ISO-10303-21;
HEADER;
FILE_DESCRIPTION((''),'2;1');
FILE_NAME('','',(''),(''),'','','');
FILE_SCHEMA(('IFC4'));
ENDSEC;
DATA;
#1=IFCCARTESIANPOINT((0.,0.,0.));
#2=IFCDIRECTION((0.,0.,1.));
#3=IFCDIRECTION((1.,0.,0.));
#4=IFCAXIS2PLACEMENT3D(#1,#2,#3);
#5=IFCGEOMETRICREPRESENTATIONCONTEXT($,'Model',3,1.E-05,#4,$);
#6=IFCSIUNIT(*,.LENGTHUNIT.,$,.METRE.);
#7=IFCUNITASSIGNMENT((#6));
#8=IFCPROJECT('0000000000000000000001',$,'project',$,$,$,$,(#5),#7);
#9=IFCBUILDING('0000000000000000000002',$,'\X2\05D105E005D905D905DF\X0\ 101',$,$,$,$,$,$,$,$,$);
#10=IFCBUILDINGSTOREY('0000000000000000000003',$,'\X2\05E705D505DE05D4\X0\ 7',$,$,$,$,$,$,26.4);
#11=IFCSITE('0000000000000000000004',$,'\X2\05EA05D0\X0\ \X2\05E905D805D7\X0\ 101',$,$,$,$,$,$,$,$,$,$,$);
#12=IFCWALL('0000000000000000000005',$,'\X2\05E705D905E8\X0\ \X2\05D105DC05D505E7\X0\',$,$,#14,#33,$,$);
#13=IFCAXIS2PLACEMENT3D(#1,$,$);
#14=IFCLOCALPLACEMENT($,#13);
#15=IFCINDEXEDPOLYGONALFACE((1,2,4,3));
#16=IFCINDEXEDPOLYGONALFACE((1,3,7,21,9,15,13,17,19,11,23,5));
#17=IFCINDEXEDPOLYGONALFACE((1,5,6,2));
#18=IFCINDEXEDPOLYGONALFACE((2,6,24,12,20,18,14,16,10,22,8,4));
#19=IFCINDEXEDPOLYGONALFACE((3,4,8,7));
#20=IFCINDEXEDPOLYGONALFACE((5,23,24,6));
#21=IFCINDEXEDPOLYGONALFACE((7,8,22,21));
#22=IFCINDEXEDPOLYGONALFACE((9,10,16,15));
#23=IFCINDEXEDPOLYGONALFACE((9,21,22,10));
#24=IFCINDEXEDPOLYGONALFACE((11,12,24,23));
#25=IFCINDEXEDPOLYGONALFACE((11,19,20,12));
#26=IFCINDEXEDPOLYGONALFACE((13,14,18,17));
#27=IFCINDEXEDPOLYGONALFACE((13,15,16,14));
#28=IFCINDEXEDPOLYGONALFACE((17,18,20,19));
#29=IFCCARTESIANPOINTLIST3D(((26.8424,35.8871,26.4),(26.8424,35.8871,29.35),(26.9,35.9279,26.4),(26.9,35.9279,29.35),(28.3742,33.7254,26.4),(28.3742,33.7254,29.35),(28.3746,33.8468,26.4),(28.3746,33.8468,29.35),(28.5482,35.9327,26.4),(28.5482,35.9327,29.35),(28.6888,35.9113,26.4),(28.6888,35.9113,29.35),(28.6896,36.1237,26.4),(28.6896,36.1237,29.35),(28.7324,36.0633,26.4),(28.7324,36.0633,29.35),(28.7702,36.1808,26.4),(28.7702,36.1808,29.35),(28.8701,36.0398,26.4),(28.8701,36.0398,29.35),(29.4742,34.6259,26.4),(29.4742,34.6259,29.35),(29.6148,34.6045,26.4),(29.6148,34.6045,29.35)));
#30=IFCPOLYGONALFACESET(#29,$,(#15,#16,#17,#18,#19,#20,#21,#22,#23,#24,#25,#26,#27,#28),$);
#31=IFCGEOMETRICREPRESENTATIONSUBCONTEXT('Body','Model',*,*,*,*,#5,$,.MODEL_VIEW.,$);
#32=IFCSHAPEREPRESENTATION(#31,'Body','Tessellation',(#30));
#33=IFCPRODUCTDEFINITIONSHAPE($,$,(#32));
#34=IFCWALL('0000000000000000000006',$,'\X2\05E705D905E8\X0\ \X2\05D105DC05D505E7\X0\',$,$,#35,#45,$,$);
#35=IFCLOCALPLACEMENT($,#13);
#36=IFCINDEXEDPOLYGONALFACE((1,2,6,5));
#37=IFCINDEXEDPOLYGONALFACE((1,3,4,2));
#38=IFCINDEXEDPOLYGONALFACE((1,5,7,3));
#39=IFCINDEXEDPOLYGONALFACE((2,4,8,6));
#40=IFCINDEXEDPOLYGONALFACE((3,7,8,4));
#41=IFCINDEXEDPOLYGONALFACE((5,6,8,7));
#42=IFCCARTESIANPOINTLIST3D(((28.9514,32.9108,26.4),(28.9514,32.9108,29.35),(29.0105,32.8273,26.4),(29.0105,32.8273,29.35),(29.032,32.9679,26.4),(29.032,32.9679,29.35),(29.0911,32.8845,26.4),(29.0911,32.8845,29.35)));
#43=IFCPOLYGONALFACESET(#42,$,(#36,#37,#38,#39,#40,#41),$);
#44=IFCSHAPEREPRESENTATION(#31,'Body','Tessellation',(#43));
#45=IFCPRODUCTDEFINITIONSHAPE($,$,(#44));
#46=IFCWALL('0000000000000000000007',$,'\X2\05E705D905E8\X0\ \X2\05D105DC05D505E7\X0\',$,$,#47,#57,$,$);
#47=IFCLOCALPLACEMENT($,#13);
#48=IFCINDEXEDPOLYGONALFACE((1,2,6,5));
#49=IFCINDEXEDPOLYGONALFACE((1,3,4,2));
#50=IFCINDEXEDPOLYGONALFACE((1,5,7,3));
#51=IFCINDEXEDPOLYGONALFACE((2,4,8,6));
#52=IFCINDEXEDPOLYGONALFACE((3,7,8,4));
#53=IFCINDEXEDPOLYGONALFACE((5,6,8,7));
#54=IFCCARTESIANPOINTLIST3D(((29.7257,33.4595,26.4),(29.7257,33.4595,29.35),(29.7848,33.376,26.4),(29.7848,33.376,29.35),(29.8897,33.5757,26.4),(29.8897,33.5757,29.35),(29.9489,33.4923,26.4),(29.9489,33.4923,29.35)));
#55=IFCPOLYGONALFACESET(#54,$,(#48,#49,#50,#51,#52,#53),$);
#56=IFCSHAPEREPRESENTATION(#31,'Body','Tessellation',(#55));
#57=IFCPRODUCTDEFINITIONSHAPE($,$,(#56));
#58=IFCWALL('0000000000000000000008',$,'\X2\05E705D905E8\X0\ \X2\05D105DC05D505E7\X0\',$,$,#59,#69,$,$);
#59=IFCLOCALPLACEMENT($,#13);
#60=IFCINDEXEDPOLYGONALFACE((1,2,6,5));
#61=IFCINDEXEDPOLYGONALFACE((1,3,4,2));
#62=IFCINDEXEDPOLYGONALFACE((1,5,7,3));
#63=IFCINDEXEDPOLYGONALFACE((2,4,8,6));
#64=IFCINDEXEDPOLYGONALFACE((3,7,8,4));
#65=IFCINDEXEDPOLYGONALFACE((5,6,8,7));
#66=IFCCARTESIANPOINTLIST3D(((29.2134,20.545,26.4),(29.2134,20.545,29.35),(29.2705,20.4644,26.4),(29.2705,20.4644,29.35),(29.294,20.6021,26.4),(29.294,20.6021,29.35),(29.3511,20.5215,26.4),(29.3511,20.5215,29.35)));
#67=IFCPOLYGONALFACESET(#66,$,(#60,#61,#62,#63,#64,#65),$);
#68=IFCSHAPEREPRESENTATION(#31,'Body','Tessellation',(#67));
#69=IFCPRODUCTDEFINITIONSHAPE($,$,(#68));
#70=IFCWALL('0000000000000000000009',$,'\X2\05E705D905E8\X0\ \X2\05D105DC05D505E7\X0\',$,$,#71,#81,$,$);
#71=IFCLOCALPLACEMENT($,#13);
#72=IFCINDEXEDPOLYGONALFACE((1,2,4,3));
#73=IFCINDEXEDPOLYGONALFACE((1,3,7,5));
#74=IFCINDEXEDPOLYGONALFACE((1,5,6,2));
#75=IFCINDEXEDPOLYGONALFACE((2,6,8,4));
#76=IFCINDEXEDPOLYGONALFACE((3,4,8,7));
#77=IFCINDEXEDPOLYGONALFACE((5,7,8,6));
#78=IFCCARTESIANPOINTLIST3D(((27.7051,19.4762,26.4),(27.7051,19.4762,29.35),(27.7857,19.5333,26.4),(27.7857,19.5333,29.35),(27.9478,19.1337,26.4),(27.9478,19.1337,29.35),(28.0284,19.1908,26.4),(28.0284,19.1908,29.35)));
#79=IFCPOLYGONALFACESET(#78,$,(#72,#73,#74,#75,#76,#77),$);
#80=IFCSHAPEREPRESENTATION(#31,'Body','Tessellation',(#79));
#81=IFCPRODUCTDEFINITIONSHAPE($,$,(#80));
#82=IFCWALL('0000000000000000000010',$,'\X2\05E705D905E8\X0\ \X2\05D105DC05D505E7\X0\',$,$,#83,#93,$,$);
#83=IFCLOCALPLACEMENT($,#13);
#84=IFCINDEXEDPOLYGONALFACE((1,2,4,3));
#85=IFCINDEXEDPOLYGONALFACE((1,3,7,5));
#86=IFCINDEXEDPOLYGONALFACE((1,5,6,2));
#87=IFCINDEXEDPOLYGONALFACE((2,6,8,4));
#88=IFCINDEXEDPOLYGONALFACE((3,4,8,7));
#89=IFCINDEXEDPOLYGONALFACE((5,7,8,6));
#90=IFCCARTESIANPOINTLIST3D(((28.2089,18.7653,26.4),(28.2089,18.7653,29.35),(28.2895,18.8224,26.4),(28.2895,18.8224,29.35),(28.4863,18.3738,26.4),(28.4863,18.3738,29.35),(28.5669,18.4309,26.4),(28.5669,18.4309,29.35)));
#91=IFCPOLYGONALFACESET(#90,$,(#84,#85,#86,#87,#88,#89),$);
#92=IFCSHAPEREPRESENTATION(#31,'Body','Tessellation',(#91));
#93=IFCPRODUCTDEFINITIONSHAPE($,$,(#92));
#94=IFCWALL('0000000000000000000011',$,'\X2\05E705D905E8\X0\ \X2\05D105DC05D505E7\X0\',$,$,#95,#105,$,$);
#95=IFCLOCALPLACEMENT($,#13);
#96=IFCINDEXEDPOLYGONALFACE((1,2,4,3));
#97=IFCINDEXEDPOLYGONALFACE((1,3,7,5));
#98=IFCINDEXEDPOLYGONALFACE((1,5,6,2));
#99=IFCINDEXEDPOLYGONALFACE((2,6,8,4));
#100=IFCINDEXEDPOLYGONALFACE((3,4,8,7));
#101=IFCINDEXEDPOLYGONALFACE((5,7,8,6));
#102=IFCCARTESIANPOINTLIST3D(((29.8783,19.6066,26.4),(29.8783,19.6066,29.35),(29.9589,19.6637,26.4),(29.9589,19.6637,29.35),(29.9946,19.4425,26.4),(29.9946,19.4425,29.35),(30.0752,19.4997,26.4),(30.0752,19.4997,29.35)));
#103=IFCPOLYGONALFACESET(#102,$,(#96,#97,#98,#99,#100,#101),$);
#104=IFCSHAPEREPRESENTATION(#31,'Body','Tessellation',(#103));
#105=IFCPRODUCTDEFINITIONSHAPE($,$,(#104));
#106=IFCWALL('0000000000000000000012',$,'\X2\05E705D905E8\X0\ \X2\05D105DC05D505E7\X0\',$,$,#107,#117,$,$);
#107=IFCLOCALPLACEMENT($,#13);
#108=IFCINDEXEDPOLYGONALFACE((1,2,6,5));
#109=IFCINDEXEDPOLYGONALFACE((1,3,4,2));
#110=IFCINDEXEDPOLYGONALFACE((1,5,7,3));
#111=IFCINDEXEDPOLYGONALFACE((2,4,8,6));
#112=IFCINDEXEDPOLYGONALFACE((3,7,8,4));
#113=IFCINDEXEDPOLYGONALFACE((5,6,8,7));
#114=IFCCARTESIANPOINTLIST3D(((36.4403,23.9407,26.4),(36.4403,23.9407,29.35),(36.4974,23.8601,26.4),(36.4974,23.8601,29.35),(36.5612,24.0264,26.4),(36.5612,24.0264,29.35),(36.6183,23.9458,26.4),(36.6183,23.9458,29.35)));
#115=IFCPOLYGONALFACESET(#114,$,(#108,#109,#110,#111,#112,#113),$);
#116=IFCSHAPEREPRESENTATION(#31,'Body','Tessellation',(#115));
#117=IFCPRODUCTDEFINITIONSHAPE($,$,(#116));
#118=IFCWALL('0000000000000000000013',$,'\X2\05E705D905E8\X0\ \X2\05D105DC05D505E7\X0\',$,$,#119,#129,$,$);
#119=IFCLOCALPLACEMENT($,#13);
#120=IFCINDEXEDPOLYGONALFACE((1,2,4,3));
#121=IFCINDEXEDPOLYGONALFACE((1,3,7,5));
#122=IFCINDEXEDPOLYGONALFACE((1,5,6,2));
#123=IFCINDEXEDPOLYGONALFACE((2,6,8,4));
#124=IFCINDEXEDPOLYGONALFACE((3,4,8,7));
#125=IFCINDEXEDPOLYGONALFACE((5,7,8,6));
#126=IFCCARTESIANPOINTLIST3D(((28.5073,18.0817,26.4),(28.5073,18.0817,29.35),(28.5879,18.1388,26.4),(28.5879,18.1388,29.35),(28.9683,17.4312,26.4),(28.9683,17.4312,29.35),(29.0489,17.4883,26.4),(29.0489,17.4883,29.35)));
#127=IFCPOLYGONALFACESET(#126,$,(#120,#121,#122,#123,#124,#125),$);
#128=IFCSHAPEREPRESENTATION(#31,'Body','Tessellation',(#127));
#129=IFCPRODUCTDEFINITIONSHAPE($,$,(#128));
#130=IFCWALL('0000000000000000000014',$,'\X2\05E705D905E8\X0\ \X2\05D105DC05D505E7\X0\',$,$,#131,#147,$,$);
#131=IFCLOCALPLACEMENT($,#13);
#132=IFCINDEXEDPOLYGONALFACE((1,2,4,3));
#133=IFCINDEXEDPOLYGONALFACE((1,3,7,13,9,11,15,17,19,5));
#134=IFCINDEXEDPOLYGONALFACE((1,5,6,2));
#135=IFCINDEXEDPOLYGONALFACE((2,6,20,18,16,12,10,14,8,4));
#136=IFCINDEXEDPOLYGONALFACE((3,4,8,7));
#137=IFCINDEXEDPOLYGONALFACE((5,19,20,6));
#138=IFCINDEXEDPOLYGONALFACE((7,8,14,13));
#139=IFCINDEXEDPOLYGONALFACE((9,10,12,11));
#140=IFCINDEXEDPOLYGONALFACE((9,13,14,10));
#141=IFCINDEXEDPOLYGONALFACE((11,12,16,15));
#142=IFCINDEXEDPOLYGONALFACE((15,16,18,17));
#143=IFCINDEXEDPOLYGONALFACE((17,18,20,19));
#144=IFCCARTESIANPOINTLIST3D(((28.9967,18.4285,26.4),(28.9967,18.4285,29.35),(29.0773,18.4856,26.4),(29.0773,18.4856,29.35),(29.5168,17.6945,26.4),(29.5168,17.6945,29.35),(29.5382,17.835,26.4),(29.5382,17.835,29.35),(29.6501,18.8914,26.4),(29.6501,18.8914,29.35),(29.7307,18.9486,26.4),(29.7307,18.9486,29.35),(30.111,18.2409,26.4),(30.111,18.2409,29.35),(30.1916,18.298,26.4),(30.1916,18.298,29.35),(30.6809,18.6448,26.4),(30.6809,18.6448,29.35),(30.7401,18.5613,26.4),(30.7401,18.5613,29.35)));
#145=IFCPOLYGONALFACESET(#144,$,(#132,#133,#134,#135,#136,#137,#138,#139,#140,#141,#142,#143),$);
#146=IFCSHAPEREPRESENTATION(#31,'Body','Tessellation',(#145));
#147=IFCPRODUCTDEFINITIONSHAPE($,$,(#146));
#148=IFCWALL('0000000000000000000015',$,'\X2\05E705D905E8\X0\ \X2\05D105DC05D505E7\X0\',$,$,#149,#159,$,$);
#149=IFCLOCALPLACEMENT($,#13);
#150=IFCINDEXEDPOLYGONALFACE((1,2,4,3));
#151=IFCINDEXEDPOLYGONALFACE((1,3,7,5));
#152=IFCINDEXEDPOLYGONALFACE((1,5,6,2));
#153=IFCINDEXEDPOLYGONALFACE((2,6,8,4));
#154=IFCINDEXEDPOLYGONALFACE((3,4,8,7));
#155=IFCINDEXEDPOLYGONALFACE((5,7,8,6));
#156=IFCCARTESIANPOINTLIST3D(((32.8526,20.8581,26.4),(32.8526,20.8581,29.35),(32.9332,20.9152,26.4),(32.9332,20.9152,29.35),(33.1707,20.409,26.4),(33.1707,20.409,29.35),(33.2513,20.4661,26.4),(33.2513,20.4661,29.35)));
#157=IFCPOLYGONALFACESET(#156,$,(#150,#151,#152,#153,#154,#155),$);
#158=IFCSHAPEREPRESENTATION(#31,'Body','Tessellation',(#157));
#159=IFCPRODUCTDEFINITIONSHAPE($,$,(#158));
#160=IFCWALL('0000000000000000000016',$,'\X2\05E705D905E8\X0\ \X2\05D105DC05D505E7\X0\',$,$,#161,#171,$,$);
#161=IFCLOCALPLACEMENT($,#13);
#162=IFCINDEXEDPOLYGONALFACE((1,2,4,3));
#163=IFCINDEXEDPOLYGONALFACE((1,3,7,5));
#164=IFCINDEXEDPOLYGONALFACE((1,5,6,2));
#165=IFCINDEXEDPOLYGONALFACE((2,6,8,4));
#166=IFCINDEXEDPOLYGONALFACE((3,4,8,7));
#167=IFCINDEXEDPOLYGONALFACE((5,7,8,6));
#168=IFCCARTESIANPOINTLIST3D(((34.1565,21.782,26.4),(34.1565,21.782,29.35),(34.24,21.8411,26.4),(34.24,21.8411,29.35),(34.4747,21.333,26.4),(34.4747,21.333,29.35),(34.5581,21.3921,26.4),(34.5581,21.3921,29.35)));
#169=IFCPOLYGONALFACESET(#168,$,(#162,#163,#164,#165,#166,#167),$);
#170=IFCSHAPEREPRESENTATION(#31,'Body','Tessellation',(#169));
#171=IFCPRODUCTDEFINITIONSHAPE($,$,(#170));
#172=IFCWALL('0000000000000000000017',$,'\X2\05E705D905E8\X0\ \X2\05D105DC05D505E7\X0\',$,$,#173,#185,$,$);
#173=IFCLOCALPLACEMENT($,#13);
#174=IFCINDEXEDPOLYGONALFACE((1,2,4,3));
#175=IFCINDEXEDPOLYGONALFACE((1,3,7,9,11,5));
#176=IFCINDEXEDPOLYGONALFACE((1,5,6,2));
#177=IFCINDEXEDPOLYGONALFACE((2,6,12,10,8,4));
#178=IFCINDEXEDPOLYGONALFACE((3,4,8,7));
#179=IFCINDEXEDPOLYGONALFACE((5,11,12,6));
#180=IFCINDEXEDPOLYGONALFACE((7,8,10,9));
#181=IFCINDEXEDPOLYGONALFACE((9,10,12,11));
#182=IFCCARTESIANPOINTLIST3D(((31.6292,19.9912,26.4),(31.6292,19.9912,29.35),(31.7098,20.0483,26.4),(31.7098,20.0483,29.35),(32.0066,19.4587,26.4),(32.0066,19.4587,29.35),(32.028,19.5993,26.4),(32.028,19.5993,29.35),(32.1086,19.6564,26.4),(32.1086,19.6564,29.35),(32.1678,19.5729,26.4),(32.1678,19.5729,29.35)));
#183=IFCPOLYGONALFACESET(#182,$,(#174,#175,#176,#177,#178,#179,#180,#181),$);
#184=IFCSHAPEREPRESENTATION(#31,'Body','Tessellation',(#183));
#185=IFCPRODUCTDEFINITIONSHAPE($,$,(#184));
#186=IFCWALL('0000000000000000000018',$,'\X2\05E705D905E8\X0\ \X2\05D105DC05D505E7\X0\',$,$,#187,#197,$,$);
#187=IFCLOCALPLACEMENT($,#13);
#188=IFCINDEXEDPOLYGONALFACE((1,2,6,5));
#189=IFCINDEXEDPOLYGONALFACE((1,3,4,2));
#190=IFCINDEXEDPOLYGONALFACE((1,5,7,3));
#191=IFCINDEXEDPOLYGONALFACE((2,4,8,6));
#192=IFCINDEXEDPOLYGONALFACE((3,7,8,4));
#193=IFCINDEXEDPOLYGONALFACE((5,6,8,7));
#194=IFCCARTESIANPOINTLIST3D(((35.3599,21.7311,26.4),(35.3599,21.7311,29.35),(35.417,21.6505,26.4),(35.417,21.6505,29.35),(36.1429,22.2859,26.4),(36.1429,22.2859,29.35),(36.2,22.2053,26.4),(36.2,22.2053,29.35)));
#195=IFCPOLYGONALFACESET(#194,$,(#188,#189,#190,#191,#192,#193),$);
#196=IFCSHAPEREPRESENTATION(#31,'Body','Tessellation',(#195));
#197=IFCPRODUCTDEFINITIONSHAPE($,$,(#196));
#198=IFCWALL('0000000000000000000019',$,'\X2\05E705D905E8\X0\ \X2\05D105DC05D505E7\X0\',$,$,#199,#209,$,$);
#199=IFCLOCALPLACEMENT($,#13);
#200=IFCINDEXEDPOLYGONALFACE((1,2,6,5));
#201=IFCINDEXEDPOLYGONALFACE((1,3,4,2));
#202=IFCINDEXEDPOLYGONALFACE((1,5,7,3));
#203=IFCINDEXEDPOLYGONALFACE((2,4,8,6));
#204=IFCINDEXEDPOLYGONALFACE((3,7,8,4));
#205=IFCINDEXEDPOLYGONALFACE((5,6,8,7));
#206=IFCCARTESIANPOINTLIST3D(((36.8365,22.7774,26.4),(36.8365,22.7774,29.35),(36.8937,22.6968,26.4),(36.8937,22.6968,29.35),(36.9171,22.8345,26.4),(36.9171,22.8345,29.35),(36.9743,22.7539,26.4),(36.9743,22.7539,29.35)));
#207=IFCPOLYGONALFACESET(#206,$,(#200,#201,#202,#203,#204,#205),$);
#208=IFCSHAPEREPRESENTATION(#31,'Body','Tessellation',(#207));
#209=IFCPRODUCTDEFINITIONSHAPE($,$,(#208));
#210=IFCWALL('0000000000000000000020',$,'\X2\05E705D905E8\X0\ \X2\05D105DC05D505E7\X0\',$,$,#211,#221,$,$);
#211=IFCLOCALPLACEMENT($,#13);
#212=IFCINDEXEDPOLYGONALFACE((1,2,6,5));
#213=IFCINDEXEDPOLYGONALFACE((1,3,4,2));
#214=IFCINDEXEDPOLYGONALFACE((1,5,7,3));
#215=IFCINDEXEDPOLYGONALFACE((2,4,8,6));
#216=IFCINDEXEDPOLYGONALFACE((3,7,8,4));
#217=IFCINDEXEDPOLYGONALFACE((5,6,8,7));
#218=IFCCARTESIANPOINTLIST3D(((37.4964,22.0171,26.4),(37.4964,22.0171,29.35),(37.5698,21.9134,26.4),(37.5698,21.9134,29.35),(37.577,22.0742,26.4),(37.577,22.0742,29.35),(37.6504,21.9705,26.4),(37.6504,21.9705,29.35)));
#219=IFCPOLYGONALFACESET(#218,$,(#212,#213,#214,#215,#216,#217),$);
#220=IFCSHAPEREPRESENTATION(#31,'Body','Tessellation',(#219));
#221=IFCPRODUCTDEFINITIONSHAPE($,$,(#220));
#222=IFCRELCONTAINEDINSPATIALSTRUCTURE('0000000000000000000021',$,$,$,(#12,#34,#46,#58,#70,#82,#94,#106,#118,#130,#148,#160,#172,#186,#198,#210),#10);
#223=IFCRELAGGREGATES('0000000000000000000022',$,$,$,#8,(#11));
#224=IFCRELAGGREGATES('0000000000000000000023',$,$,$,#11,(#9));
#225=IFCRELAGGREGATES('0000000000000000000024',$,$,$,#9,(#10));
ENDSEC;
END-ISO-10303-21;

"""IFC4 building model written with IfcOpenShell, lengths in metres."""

from ifc_helpers import new_model, si_unit, frame, origin_with_axes, context, subcontext, project, spatial, polyline, outline, extrude, element, save


model = new_model("IFC4")

# Units and contexts
model_context = context("Model", 3, precision=1e-05, world=origin_with_axes())
body_context = subcontext(model_context, "Body", "Model", "MODEL_VIEW")
ifc_project = project(units=[si_unit("LENGTHUNIT", "METRE")], contexts=[model_context])

# Site, building, storey
site = spatial("IfcSite", under=ifc_project, Name="תא שטח 101")
building = spatial("IfcBuilding", under=site, Name="בניין 101")
storey = spatial("IfcBuildingStorey", under=building, Name="קומה 7", Elevation=26.4)

# Walls
element("IfcWall", 1, inside=storey, Name="קיר בלוק", context=body_context, shape_type="SweptSolid", body=[
    extrude(outline(polyline([(26.9, 35.9279), (26.8424, 35.8871), (28.3742, 33.7254), (29.6148, 34.6045), (28.6888, 35.9113), (28.8701, 36.0398), (28.7702, 36.1808), (28.6896, 36.1237), (28.7324, 36.0633), (28.5482, 35.9327), (29.4742, 34.6259), (28.3746, 33.8468), (26.9, 35.9279)])), frame((0.0, 0.0, 26.4)), (0.0, 0.0, 1.0), 2.95),
])
element("IfcWall", 2, inside=storey, Name="קיר בלוק", context=body_context, shape_type="SweptSolid", body=[
    extrude(outline(polyline([(29.0105, 32.8273), (29.0911, 32.8845), (29.032, 32.9679), (28.9514, 32.9108), (29.0105, 32.8273)])), frame((0.0, 0.0, 26.4)), (0.0, 0.0, 1.0), 2.95),
])
element("IfcWall", 3, inside=storey, Name="קיר בלוק", context=body_context, shape_type="SweptSolid", body=[
    extrude(outline(polyline([(29.9489, 33.4923), (29.8897, 33.5757), (29.7257, 33.4595), (29.7848, 33.376), (29.9489, 33.4923)])), frame((0.0, 0.0, 26.4)), (0.0, 0.0, 1.0), 2.95),
])
element("IfcWall", 4, inside=storey, Name="קיר בלוק", context=body_context, shape_type="SweptSolid", body=[
    extrude(outline(polyline([(29.2705, 20.4644), (29.3511, 20.5215), (29.294, 20.6021), (29.2134, 20.545), (29.2705, 20.4644)])), frame((0.0, 0.0, 26.4)), (0.0, 0.0, 1.0), 2.95),
])
element("IfcWall", 5, inside=storey, Name="קיר בלוק", context=body_context, shape_type="SweptSolid", body=[
    extrude(outline(polyline([(27.7857, 19.5333), (27.7051, 19.4762), (27.9478, 19.1337), (28.0284, 19.1908), (27.7857, 19.5333)])), frame((0.0, 0.0, 26.4)), (0.0, 0.0, 1.0), 2.95),
])
element("IfcWall", 6, inside=storey, Name="קיר בלוק", context=body_context, shape_type="SweptSolid", body=[
    extrude(outline(polyline([(28.2895, 18.8224), (28.2089, 18.7653), (28.4863, 18.3738), (28.5669, 18.4309), (28.2895, 18.8224)])), frame((0.0, 0.0, 26.4)), (0.0, 0.0, 1.0), 2.95),
])
element("IfcWall", 7, inside=storey, Name="קיר בלוק", context=body_context, shape_type="SweptSolid", body=[
    extrude(outline(polyline([(29.9946, 19.4425), (30.0752, 19.4997), (29.9589, 19.6637), (29.8783, 19.6066), (29.9946, 19.4425)])), frame((0.0, 0.0, 26.4)), (0.0, 0.0, 1.0), 2.95),
])
element("IfcWall", 8, inside=storey, Name="קיר בלוק", context=body_context, shape_type="SweptSolid", body=[
    extrude(outline(polyline([(36.5612, 24.0264), (36.4403, 23.9407), (36.4974, 23.8601), (36.6183, 23.9458), (36.5612, 24.0264)])), frame((0.0, 0.0, 26.4)), (0.0, 0.0, 1.0), 2.95),
])
element("IfcWall", 9, inside=storey, Name="קיר בלוק", context=body_context, shape_type="SweptSolid", body=[
    extrude(outline(polyline([(28.5879, 18.1388), (28.5073, 18.0817), (28.9683, 17.4312), (29.0489, 17.4883), (28.5879, 18.1388)])), frame((0.0, 0.0, 26.4)), (0.0, 0.0, 1.0), 2.95),
])
element("IfcWall", 10, inside=storey, Name="קיר בלוק", context=body_context, shape_type="SweptSolid", body=[
    extrude(outline(polyline([(30.111, 18.2409), (29.5382, 17.835), (29.0773, 18.4856), (28.9967, 18.4285), (29.5168, 17.6945), (30.7401, 18.5613), (30.6809, 18.6448), (30.1916, 18.298), (29.7307, 18.9486), (29.6501, 18.8914), (30.111, 18.2409)])), frame((0.0, 0.0, 26.4)), (0.0, 0.0, 1.0), 2.95),
])
element("IfcWall", 11, inside=storey, Name="קיר בלוק", context=body_context, shape_type="SweptSolid", body=[
    extrude(outline(polyline([(33.1707, 20.409), (33.2513, 20.4661), (32.9332, 20.9152), (32.8526, 20.8581), (33.1707, 20.409)])), frame((0.0, 0.0, 26.4)), (0.0, 0.0, 1.0), 2.95),
])
element("IfcWall", 12, inside=storey, Name="קיר בלוק", context=body_context, shape_type="SweptSolid", body=[
    extrude(outline(polyline([(34.5581, 21.3921), (34.24, 21.8411), (34.1565, 21.782), (34.4747, 21.333), (34.5581, 21.3921)])), frame((0.0, 0.0, 26.4)), (0.0, 0.0, 1.0), 2.95),
])
element("IfcWall", 13, inside=storey, Name="קיר בלוק", context=body_context, shape_type="SweptSolid", body=[
    extrude(outline(polyline([(32.1678, 19.5729), (32.1086, 19.6564), (32.028, 19.5993), (31.7098, 20.0483), (31.6292, 19.9912), (32.0066, 19.4587), (32.1678, 19.5729)])), frame((0.0, 0.0, 26.4)), (0.0, 0.0, 1.0), 2.95),
])
element("IfcWall", 14, inside=storey, Name="קיר בלוק", context=body_context, shape_type="SweptSolid", body=[
    extrude(outline(polyline([(35.3599, 21.7311), (35.417, 21.6505), (36.2, 22.2053), (36.1429, 22.2859), (35.3599, 21.7311)])), frame((0.0, 0.0, 26.4)), (0.0, 0.0, 1.0), 2.95),
])
element("IfcWall", 15, inside=storey, Name="קיר בלוק", context=body_context, shape_type="SweptSolid", body=[
    extrude(outline(polyline([(36.9171, 22.8345), (36.8365, 22.7774), (36.8937, 22.6968), (36.9743, 22.7539), (36.9171, 22.8345)])), frame((0.0, 0.0, 26.4)), (0.0, 0.0, 1.0), 2.95),
])
element("IfcWall", 16, inside=storey, Name="קיר בלוק", context=body_context, shape_type="SweptSolid", body=[
    extrude(outline(polyline([(37.4964, 22.0171), (37.5698, 21.9134), (37.6504, 21.9705), (37.577, 22.0742), (37.4964, 22.0171)])), frame((0.0, 0.0, 26.4)), (0.0, 0.0, 1.0), 2.95),
])

save(model, "model.ifc")
